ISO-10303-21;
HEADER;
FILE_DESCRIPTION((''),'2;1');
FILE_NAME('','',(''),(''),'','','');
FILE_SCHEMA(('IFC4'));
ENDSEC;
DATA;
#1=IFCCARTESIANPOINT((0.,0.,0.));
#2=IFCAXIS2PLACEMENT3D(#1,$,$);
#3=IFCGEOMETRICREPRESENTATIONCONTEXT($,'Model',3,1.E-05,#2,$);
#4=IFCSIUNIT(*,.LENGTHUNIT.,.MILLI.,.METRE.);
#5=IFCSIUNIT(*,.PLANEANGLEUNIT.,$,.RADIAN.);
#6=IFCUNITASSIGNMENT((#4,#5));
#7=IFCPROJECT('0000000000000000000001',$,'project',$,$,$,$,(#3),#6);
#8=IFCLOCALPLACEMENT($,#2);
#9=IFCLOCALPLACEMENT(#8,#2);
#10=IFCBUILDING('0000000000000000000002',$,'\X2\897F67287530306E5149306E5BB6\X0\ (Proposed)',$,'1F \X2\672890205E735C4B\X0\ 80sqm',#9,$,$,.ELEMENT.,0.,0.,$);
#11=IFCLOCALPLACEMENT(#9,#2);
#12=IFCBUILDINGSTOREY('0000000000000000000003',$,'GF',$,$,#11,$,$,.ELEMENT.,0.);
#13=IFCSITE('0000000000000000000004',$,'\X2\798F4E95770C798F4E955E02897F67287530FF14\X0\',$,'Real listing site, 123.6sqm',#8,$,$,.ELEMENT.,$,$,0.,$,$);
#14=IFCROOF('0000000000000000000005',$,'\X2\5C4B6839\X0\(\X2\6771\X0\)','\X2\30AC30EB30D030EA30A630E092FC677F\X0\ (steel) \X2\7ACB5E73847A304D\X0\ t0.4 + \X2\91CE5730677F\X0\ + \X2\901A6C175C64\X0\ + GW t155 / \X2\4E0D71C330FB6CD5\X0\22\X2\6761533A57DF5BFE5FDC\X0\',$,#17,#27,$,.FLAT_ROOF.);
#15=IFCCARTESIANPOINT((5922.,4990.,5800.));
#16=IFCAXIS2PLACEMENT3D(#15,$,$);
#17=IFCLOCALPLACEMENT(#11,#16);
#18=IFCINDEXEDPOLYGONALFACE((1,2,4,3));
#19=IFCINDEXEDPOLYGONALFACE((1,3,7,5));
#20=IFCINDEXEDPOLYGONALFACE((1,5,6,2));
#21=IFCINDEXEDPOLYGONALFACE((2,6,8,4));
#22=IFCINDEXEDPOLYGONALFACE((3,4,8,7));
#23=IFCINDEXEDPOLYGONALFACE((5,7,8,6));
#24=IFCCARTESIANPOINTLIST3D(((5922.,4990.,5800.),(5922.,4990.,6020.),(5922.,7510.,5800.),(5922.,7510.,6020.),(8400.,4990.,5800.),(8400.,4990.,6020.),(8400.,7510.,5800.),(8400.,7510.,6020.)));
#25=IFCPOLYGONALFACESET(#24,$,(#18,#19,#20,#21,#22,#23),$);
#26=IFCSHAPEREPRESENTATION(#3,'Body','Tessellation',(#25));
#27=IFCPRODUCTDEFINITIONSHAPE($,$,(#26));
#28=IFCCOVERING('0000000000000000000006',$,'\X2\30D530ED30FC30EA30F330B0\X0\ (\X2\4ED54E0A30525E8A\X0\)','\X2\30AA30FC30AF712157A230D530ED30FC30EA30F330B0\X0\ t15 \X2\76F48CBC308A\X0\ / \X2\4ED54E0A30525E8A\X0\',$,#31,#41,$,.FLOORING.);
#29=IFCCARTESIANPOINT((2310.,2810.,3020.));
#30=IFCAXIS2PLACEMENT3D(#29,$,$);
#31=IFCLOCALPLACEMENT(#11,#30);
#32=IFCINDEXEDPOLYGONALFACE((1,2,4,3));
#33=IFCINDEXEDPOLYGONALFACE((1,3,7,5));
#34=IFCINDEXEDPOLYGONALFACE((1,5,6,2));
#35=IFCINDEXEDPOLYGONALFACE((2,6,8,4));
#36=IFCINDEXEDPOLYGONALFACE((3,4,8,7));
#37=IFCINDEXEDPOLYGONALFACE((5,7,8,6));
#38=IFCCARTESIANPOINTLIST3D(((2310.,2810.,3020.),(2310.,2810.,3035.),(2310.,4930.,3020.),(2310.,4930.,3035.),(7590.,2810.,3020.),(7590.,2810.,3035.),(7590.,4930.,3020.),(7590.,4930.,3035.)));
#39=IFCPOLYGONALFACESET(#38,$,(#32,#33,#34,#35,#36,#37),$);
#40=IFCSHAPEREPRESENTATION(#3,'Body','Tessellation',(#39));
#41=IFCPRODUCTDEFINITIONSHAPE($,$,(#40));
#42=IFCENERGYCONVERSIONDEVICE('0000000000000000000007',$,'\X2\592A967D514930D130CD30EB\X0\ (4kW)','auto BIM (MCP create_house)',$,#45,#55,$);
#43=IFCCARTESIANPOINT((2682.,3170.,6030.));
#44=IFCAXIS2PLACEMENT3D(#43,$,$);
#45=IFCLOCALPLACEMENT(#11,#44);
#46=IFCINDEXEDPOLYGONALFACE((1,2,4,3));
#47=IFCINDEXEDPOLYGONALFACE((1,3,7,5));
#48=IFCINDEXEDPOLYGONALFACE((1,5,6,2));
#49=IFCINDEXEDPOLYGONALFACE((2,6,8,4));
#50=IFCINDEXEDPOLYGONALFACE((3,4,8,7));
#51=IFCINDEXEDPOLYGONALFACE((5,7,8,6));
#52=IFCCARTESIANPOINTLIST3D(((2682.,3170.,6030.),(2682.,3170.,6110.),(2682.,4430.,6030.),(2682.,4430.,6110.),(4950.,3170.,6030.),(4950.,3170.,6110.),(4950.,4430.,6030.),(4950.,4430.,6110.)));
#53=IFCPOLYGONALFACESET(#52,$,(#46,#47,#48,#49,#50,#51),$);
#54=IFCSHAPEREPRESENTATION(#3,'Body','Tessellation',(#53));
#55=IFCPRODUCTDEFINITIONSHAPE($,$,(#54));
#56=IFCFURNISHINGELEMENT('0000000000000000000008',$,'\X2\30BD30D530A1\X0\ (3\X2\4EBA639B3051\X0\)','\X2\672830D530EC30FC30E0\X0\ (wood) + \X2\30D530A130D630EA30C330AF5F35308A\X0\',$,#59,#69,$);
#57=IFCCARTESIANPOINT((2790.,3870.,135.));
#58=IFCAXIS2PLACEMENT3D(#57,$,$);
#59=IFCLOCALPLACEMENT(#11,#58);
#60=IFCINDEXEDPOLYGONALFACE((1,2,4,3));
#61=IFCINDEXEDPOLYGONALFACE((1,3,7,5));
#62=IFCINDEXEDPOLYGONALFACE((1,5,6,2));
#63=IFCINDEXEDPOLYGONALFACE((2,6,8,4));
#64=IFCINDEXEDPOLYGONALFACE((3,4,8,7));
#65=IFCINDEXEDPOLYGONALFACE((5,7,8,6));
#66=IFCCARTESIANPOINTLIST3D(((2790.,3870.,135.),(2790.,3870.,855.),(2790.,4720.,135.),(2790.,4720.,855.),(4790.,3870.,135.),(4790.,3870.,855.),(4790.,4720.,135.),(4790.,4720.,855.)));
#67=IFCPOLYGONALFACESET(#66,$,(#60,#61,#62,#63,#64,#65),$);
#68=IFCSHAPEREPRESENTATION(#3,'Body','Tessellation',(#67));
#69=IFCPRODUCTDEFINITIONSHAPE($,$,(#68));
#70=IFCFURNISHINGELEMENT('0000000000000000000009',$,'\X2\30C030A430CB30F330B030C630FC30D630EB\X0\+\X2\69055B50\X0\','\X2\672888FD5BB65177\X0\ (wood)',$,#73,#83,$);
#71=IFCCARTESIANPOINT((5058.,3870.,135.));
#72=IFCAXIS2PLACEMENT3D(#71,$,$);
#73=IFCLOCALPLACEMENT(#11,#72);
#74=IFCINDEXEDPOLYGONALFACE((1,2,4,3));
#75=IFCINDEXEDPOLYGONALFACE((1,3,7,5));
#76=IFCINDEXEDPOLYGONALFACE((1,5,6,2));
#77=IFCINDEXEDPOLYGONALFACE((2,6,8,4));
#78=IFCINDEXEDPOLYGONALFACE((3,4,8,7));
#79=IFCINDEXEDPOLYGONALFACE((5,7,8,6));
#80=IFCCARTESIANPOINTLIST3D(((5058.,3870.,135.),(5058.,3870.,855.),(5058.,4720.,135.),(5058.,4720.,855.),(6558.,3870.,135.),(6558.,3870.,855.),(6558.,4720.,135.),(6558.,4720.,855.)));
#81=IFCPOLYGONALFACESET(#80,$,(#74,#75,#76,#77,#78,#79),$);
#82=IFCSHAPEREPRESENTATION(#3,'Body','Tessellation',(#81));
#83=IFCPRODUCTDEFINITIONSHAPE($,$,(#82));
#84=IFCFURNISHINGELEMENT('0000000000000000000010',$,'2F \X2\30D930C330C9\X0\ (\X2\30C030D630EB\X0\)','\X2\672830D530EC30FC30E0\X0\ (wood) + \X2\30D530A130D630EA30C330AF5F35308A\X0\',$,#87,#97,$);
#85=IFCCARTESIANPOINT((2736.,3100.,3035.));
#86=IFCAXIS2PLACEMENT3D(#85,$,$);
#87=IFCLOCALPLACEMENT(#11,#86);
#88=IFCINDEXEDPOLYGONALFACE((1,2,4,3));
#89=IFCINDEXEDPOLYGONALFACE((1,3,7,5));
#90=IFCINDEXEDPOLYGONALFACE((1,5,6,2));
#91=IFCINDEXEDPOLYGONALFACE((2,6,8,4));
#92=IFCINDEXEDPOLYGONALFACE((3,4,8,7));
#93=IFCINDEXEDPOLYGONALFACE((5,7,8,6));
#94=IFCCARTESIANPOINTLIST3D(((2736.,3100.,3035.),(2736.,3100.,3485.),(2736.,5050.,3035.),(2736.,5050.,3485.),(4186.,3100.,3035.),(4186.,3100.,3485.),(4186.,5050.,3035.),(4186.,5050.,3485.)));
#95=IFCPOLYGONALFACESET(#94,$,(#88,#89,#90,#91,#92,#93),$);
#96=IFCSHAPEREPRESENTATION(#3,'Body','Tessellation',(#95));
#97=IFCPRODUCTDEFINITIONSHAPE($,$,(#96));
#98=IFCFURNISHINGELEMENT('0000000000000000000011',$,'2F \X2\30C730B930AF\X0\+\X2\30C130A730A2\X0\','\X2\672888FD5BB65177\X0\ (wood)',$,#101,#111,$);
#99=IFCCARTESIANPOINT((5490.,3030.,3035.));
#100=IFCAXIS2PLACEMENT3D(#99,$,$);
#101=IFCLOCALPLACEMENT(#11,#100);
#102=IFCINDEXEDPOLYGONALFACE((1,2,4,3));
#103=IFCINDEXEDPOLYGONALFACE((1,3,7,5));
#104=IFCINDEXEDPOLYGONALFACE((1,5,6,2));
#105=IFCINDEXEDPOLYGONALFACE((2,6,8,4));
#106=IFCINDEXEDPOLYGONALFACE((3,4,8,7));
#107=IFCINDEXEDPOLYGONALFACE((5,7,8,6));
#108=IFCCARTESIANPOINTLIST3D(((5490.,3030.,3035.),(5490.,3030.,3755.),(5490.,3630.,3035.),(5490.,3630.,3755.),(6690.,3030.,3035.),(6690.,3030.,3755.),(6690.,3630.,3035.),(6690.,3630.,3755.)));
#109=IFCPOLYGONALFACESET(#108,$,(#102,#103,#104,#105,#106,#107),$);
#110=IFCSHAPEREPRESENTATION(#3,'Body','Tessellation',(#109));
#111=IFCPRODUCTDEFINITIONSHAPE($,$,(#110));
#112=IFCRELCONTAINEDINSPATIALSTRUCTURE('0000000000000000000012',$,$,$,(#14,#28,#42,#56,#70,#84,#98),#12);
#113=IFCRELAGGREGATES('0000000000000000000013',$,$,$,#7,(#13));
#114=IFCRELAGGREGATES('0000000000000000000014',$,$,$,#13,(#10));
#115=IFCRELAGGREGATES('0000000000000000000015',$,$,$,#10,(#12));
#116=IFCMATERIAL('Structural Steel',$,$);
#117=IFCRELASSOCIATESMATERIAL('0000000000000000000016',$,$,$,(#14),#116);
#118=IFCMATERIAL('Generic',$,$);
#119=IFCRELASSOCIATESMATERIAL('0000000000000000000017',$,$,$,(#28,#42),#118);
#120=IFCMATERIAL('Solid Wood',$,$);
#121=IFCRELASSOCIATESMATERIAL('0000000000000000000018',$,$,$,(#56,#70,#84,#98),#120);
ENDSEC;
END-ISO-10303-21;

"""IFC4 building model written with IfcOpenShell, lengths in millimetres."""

from ifc_helpers import new_model, si_unit, frame, frame_2d, origin, place, context, project, spatial, rectangle, extrude, material, element, save


model = new_model("IFC4")

# Units and contexts
model_context = context("Model", 3, precision=1e-05, world=origin())
ifc_project = project(units=[si_unit("LENGTHUNIT", "METRE", prefix="MILLI"), si_unit("PLANEANGLEUNIT", "RADIAN")], contexts=[model_context])

# Site, building, storey
site_placement = place(None, origin())
site = spatial("IfcSite", under=ifc_project, at=site_placement, Name="福井県福井市西木田４", ObjectType="Real listing site, 123.6sqm", CompositionType="ELEMENT", RefElevation=0.0)
building_placement = place(site_placement, origin())
building = spatial("IfcBuilding", under=site, at=building_placement, Name="西木田の光の家 (Proposed)", ObjectType="1F 木造平屋 80sqm", CompositionType="ELEMENT", ElevationOfRefHeight=0.0, ElevationOfTerrain=0.0)
storey_placement = place(building_placement, origin())
storey = spatial("IfcBuildingStorey", under=building, at=storey_placement, Name="GF", CompositionType="ELEMENT", Elevation=0.0)

# Shared definitions
ifc_material_1 = material(Name="Solid Wood")

# Roof
ifc_material_2 = material(Name="Structural Steel")
roof_1_placement = place(storey_placement, frame((5922.0, 4990.0, 5800.0)))
element("IfcRoof", 1, at=roof_1_placement, inside=storey, material=ifc_material_2, Name="屋根(東)", Description="ガルバリウム鋼板 (steel) 立平葺き t0.4 + 野地板 + 通気層 + GW t155 / 不燃・法22条区域対応", PredefinedType="FLAT_ROOF", context=model_context, shape_type="SweptSolid", body=[
    extrude(rectangle(XDim=2478.0, YDim=2520.0, at=frame_2d((1239.0, 1260.0))), frame((5922.0, 4990.0, 5800.0)), (0.0, 0.0, 1.0), 220.0),
])

# Covering
ifc_material_3 = material(Name="Generic")
covering_placement = place(storey_placement, frame((2310.0, 2810.0, 3020.0)))
element("IfcCovering", 2, at=covering_placement, inside=storey, material=ifc_material_3, Name="フローリング (仕上げ床)", Description="オーク無垢フローリング t15 直貼り / 仕上げ床", PredefinedType="FLOORING", context=model_context, shape_type="SweptSolid", body=[
    extrude(rectangle(XDim=5280.0, YDim=2120.0, at=frame_2d((2640.0, 1060.0))), frame((2310.0, 2810.0, 3020.0)), (0.0, 0.0, 1.0), 15.0),
])

# Energy conversion device
energy_conversion_device_placement = place(storey_placement, frame((2682.0, 3170.0, 6030.0)))
element("IfcEnergyConversionDevice", 3, at=energy_conversion_device_placement, inside=storey, material=ifc_material_3, Name="太陽光パネル (4kW)", Description="auto BIM (MCP create_house)", context=model_context, shape_type="SweptSolid", body=[
    extrude(rectangle(XDim=2268.0, YDim=1260.0, at=frame_2d((1134.0, 630.0))), frame((2682.0, 3170.0, 6030.0)), (0.0, 0.0, 1.0), 80.0),
])

# Furnishing elements
furnishing_1_placement = place(storey_placement, frame((2790.0, 3870.0, 135.0)))
element("IfcFurnishingElement", 4, at=furnishing_1_placement, inside=storey, material=ifc_material_1, Name="ソファ (3人掛け)", Description="木フレーム (wood) + ファブリック張り", context=model_context, shape_type="SweptSolid", body=[
    extrude(rectangle(XDim=2000.0, YDim=850.0, at=frame_2d((1000.0, 425.0))), frame((2790.0, 3870.0, 135.0)), (0.0, 0.0, 1.0), 720.0),
])
furnishing_2_placement = place(storey_placement, frame((5058.0, 3870.0, 135.0)))
element("IfcFurnishingElement", 5, at=furnishing_2_placement, inside=storey, material=ifc_material_1, Name="ダイニングテーブル+椅子", Description="木製家具 (wood)", context=model_context, shape_type="SweptSolid", body=[
    extrude(rectangle(XDim=1500.0, YDim=850.0, at=frame_2d((750.0, 425.0))), frame((5058.0, 3870.0, 135.0)), (0.0, 0.0, 1.0), 720.0),
])
furnishing_3_placement = place(storey_placement, frame((2736.0, 3100.0, 3035.0)))
element("IfcFurnishingElement", 6, at=furnishing_3_placement, inside=storey, material=ifc_material_1, Name="2F ベッド (ダブル)", Description="木フレーム (wood) + ファブリック張り", context=model_context, shape_type="SweptSolid", body=[
    extrude(rectangle(XDim=1450.0, YDim=1950.0, at=frame_2d((725.0, 975.0))), frame((2736.0, 3100.0, 3035.0)), (0.0, 0.0, 1.0), 450.0),
])
furnishing_4_placement = place(storey_placement, frame((5490.0, 3030.0, 3035.0)))
element("IfcFurnishingElement", 7, at=furnishing_4_placement, inside=storey, material=ifc_material_1, Name="2F デスク+チェア", Description="木製家具 (wood)", context=model_context, shape_type="SweptSolid", body=[
    extrude(rectangle(XDim=1200.0, YDim=600.0, at=frame_2d((600.0, 300.0))), frame((5490.0, 3030.0, 3035.0)), (0.0, 0.0, 1.0), 720.0),
])

save(model, "model.ifc")
